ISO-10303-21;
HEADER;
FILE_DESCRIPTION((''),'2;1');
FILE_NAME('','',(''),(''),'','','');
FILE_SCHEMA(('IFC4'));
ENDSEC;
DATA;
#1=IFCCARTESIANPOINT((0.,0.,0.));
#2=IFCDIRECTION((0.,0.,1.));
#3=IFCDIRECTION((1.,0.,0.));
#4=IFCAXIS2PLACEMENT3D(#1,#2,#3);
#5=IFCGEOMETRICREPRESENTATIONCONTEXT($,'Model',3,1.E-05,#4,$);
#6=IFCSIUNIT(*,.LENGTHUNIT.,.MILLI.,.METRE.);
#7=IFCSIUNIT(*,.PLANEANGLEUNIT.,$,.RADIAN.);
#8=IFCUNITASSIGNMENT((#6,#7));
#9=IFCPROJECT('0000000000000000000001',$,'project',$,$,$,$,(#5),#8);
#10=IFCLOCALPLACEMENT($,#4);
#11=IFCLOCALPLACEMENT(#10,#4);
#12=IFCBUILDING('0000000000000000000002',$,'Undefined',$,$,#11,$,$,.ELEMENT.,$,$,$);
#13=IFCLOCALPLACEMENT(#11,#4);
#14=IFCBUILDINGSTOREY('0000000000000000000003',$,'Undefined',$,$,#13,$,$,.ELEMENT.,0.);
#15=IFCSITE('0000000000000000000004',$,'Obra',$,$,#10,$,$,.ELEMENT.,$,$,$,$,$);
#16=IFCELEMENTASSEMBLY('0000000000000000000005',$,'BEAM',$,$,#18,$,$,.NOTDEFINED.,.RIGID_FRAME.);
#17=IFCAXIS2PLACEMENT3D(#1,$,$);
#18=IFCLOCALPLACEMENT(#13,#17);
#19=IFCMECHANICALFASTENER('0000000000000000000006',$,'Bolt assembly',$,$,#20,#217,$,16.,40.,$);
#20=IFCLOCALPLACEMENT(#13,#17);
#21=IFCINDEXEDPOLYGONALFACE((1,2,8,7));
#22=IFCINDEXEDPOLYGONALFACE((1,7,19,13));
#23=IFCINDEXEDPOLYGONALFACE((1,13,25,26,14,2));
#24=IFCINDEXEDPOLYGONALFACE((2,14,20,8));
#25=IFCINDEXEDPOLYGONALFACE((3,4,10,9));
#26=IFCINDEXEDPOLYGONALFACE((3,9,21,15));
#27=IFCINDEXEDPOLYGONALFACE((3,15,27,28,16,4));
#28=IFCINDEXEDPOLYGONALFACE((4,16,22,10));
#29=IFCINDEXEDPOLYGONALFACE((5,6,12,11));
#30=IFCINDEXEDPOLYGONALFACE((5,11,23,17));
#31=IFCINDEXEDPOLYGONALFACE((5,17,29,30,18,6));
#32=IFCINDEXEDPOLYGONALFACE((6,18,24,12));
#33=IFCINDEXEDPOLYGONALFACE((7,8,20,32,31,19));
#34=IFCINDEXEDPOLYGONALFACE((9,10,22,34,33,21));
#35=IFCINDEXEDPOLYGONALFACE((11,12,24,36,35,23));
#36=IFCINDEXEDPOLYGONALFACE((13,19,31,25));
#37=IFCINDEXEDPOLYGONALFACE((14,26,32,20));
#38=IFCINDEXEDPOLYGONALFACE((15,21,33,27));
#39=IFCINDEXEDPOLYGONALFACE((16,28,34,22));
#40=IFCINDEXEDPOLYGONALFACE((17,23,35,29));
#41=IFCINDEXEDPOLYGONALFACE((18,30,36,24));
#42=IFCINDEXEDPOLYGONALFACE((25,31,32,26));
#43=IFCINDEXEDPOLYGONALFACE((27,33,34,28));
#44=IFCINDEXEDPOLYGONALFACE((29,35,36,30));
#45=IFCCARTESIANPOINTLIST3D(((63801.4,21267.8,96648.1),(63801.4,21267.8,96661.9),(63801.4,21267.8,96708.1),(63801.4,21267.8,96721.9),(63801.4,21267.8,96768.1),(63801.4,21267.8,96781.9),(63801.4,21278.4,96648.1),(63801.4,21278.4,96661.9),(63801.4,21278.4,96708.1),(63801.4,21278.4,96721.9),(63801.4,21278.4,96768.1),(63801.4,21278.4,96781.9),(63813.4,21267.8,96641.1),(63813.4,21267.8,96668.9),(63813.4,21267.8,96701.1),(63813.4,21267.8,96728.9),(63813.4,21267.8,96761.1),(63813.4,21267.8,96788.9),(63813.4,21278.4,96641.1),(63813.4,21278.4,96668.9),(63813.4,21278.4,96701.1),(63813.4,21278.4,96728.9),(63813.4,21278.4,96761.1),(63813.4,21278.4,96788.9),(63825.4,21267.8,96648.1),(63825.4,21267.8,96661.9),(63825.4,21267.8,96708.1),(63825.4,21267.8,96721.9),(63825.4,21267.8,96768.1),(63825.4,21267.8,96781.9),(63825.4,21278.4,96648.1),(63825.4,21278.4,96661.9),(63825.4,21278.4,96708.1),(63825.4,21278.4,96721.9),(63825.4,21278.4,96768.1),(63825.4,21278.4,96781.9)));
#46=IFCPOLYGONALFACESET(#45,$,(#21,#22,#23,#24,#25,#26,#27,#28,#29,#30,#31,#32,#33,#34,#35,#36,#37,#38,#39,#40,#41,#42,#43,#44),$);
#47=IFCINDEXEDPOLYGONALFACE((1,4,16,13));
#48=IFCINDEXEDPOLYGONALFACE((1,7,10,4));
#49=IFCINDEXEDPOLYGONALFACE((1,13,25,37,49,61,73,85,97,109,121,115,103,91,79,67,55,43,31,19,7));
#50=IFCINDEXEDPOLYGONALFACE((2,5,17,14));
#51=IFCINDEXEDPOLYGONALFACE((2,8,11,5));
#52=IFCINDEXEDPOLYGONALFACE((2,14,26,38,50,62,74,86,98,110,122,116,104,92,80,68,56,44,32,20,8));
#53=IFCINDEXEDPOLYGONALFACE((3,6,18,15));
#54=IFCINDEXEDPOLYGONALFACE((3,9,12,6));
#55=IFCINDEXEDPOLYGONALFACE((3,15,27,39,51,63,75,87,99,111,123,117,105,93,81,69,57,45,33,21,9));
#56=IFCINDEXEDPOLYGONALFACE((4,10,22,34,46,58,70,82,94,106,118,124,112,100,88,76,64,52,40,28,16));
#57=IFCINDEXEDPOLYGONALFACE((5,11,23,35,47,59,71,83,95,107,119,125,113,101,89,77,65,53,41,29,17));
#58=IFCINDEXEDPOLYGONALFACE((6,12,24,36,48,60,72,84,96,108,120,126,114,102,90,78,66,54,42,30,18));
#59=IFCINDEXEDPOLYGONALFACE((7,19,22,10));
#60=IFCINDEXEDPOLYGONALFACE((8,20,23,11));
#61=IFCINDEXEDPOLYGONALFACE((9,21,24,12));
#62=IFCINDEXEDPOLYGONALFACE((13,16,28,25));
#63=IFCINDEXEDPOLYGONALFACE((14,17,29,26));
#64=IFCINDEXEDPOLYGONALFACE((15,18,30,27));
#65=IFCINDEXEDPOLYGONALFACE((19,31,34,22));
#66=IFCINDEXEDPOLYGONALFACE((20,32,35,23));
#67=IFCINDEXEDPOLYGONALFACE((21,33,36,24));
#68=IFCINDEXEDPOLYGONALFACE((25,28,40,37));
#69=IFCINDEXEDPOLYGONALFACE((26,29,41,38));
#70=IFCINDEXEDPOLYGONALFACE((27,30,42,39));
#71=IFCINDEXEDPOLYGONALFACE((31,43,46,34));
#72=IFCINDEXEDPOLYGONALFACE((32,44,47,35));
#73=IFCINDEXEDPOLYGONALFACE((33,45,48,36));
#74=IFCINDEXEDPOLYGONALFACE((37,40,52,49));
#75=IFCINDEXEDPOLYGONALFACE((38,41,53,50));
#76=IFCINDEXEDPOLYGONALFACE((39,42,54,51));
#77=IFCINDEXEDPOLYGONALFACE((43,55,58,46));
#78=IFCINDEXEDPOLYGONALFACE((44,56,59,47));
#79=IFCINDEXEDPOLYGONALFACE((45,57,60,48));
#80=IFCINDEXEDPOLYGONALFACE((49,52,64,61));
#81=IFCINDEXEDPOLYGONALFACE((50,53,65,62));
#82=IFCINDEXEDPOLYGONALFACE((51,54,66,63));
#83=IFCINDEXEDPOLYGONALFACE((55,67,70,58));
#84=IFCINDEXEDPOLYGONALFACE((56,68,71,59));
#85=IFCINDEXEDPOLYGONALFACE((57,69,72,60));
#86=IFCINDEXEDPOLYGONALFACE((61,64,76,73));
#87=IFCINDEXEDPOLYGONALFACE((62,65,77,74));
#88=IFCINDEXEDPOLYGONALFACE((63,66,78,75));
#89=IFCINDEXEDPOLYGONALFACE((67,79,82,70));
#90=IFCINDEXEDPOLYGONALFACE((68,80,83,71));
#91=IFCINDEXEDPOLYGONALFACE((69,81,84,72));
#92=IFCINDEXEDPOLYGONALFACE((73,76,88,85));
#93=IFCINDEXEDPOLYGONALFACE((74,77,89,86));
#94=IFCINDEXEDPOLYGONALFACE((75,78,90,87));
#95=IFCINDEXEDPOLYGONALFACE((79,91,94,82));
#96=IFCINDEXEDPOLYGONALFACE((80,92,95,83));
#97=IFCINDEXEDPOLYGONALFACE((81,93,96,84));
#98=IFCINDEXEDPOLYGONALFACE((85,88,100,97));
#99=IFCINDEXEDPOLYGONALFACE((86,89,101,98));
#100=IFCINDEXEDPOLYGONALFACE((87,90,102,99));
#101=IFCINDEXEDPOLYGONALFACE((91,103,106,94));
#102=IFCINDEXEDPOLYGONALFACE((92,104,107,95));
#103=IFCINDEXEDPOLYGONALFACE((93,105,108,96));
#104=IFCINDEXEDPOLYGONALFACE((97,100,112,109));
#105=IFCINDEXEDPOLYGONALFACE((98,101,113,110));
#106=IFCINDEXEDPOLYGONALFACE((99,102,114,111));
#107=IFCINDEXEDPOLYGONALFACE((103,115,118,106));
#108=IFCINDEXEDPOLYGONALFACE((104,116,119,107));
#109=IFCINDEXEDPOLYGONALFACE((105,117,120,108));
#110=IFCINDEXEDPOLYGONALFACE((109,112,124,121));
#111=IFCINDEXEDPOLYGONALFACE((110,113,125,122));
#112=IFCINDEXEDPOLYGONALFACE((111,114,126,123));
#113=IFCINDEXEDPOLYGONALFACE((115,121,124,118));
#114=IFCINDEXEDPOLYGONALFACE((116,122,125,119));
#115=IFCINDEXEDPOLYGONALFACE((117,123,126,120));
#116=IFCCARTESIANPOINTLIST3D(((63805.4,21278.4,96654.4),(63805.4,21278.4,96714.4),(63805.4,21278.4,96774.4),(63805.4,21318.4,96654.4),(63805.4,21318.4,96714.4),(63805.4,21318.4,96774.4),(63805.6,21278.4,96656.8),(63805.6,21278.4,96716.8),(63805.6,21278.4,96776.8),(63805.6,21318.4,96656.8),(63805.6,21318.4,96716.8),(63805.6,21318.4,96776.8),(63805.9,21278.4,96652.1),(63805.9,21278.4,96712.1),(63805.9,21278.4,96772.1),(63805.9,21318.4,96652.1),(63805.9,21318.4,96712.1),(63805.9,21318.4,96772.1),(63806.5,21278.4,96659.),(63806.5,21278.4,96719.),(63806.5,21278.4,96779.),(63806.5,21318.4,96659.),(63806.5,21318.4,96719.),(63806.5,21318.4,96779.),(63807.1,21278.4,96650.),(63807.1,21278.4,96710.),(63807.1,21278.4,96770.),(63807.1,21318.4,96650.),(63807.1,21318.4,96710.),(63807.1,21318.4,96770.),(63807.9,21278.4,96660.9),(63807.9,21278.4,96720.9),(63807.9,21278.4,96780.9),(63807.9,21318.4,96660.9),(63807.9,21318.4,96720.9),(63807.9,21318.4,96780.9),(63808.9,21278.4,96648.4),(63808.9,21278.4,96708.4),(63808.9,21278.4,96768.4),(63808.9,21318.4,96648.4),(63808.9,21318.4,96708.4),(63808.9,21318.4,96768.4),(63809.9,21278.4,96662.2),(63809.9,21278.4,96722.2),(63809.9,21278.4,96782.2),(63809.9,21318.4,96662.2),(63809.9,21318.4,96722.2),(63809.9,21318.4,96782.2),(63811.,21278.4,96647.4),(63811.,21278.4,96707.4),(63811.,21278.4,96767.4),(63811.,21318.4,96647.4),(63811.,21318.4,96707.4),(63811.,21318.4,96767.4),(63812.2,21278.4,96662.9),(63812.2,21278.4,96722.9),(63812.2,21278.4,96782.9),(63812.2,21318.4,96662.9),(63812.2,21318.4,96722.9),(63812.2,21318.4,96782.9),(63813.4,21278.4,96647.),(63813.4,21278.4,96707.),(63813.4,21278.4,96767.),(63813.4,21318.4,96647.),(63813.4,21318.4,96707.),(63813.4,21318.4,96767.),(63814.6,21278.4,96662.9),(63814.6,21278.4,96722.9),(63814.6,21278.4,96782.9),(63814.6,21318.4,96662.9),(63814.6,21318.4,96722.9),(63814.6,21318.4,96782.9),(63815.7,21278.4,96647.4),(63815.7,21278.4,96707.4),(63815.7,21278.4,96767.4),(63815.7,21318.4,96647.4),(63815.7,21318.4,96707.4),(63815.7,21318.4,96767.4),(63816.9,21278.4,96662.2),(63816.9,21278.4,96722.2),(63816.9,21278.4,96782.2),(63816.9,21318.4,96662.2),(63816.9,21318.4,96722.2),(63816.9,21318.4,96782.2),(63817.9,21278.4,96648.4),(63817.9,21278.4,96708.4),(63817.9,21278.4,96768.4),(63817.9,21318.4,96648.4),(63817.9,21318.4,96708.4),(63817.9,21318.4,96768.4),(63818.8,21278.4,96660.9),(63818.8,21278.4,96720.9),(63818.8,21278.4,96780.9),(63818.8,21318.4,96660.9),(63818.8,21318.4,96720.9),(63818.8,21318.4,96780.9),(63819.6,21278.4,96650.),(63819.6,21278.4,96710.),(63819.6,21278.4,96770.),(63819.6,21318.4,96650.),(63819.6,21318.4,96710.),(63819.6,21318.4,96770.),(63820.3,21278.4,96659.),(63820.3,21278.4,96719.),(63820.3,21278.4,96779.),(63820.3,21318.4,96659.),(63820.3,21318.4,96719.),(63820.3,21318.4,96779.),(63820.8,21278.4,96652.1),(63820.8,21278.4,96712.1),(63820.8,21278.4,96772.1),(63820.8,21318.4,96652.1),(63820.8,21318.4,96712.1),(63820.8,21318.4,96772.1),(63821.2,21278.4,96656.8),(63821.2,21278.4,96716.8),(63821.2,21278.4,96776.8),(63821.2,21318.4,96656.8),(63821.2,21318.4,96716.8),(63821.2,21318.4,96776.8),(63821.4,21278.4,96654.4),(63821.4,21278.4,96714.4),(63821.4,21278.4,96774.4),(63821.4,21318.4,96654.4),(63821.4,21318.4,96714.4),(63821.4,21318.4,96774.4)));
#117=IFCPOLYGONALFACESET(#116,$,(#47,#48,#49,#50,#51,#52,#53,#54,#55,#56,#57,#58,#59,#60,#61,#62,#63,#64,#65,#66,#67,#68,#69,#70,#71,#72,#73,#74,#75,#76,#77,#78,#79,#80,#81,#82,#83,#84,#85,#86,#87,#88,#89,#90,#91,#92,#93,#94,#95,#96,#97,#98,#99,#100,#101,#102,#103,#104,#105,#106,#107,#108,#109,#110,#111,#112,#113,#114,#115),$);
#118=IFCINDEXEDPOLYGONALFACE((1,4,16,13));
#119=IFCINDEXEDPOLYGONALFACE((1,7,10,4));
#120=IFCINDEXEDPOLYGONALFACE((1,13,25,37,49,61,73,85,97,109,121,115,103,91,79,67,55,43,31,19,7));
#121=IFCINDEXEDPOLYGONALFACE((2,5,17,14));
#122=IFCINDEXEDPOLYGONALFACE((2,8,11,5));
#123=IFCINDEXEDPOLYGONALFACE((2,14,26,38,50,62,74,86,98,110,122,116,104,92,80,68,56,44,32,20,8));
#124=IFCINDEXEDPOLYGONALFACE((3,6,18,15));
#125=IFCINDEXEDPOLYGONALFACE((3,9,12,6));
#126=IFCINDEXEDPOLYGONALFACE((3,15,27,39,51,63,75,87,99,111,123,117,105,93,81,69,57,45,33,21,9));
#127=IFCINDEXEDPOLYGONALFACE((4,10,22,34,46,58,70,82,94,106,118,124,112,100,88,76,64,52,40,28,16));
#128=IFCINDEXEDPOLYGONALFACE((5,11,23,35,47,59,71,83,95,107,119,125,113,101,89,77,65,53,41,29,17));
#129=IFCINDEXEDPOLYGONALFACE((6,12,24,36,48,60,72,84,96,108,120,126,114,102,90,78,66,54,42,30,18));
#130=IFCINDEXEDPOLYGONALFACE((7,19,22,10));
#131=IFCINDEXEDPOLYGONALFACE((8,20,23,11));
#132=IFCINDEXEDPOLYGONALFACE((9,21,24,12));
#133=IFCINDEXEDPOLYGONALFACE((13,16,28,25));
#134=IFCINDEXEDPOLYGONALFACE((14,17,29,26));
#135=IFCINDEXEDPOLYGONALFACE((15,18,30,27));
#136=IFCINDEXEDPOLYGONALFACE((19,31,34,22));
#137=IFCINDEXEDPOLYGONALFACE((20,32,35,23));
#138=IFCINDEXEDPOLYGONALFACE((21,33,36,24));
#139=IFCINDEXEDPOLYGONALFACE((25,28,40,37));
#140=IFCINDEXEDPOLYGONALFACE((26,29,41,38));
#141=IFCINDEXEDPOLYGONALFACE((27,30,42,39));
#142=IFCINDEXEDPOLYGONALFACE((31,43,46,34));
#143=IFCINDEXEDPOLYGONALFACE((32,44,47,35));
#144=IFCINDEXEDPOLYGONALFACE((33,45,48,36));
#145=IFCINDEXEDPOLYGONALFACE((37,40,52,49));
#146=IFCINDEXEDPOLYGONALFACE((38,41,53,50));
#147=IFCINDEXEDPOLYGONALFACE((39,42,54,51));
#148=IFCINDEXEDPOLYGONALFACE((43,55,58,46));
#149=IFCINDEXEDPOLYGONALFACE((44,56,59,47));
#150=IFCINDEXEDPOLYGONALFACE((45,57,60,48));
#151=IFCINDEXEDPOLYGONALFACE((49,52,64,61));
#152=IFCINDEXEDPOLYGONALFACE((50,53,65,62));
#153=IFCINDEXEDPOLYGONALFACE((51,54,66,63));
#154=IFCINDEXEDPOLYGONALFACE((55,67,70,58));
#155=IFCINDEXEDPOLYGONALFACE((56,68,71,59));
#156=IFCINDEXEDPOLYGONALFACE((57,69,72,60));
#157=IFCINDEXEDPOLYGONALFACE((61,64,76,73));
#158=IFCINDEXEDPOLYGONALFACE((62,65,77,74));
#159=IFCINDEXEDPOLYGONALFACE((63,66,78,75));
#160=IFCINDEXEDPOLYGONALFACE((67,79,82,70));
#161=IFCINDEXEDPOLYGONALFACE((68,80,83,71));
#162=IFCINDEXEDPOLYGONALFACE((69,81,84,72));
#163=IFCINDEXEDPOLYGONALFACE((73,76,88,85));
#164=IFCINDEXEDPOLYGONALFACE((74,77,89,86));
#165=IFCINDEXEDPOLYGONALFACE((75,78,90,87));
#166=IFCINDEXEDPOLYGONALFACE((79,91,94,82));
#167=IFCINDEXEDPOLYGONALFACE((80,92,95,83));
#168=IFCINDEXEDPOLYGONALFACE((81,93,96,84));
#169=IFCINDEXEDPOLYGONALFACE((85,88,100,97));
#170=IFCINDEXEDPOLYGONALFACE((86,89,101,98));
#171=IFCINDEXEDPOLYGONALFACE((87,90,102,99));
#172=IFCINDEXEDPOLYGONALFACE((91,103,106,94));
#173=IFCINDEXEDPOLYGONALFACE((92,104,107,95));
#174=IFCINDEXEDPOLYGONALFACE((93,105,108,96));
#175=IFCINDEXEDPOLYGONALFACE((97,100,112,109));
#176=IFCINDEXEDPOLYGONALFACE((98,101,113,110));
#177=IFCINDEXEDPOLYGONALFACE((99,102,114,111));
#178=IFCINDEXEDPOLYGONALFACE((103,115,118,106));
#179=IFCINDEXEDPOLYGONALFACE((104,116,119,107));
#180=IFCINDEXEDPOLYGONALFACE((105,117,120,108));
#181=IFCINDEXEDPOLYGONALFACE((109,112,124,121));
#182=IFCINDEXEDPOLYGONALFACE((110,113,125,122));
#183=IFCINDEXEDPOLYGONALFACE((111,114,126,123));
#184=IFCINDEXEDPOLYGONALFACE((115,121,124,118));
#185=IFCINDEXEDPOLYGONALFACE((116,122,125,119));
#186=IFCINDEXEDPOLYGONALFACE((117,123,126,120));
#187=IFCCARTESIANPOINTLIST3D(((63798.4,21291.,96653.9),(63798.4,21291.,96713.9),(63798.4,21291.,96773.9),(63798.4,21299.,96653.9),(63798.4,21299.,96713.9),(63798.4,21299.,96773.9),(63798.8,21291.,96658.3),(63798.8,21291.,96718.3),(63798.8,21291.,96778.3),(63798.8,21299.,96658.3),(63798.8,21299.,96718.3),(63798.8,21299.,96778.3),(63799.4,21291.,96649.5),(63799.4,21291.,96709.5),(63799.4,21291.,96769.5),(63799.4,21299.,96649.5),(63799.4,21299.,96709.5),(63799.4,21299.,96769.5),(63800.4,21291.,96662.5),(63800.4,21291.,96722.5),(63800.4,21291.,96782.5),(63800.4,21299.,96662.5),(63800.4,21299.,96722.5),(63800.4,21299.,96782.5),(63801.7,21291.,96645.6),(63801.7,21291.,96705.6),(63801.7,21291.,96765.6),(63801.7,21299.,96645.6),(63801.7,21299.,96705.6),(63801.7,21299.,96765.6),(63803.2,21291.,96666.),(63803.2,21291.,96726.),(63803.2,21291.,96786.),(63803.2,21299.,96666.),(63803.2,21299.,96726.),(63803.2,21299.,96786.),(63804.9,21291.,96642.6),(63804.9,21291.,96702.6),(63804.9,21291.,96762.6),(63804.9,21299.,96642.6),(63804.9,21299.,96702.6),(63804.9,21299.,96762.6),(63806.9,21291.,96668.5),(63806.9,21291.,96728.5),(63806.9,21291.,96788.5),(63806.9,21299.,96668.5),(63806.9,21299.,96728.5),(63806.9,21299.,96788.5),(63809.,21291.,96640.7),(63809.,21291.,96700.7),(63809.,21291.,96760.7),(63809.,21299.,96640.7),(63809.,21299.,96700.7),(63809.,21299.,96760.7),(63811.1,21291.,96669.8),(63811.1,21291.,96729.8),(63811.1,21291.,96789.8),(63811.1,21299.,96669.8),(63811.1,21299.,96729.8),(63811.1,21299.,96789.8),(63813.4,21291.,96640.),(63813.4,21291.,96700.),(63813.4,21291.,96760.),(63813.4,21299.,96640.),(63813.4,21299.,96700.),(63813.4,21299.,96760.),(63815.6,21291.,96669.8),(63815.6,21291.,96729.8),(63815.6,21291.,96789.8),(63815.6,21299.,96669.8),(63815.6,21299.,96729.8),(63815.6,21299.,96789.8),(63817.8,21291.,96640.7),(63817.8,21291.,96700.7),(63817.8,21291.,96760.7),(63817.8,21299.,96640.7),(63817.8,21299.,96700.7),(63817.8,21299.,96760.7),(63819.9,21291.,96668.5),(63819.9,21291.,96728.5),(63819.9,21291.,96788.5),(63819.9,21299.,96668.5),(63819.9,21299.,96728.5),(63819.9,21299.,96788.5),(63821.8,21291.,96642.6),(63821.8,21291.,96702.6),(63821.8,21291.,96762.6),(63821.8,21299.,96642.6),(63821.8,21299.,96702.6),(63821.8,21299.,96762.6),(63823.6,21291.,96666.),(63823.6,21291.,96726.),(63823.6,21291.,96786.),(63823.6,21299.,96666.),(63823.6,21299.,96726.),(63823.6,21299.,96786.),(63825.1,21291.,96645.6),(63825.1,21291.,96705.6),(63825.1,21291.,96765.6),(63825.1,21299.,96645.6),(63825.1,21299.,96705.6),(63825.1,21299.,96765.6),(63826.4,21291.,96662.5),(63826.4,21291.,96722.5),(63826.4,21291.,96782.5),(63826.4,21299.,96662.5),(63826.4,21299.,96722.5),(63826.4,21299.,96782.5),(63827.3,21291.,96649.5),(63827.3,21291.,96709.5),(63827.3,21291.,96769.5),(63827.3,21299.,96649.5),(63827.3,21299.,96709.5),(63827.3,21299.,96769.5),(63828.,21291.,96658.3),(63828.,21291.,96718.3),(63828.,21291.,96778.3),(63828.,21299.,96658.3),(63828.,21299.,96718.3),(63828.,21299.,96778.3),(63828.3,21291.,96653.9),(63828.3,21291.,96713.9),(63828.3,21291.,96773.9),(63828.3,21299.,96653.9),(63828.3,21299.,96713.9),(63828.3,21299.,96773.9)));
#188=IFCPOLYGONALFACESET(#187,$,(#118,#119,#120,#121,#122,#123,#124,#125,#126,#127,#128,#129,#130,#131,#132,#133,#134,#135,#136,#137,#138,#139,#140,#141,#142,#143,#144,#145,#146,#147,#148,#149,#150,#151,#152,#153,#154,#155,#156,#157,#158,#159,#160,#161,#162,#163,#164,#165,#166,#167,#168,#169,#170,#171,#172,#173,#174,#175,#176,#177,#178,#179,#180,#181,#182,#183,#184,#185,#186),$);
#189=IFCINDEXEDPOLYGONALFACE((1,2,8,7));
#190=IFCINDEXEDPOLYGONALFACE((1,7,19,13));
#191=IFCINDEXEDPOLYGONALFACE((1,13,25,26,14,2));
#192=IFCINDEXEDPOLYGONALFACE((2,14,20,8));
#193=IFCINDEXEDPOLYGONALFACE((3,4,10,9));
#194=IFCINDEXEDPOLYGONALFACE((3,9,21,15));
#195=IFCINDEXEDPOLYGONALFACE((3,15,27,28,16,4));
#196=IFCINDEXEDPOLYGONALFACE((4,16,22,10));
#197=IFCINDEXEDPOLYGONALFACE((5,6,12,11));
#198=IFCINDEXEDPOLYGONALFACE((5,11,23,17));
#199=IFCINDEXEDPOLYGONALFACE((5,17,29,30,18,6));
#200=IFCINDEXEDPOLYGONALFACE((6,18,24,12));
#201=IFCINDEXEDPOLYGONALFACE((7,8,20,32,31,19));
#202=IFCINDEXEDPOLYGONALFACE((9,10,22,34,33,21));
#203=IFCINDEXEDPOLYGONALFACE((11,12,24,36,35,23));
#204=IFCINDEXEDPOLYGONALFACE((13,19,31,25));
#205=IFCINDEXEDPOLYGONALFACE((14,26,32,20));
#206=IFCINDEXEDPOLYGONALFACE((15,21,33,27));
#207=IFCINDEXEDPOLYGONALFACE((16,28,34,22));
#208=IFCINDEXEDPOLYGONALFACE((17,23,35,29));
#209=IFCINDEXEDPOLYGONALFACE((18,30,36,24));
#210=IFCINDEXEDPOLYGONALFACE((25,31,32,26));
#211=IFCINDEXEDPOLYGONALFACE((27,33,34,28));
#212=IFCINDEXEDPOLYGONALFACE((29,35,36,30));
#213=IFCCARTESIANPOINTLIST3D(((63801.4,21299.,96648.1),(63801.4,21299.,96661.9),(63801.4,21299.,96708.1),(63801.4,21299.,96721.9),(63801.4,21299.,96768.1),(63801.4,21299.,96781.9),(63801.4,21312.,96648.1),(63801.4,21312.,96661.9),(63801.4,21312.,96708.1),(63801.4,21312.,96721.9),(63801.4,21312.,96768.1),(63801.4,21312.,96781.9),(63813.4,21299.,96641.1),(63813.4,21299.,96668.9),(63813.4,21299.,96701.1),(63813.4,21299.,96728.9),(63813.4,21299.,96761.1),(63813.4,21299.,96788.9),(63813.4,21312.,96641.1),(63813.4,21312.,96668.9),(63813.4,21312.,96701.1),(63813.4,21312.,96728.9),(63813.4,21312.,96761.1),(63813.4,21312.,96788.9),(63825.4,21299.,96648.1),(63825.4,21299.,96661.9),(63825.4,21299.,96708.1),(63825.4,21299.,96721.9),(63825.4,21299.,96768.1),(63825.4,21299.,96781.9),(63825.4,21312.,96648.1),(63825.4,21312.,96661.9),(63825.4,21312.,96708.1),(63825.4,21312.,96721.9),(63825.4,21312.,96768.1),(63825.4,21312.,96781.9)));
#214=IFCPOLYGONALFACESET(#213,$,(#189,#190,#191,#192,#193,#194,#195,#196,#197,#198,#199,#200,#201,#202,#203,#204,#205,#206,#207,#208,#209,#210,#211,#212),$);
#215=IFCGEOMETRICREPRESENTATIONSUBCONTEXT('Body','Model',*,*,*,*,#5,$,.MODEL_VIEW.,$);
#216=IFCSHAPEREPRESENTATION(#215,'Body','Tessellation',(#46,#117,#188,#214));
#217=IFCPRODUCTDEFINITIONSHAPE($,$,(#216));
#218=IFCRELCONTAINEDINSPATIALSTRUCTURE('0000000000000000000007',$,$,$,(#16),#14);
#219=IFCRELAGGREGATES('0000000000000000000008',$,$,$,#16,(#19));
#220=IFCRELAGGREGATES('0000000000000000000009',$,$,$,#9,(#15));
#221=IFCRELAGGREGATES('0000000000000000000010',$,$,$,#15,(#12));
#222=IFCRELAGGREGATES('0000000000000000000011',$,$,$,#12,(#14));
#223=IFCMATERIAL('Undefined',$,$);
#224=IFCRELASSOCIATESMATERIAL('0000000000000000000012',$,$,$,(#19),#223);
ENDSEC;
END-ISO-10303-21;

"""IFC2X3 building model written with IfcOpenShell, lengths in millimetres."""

from ifc_helpers import new_model, si_unit, frame, origin_with_axes, origin_2d_with_axis, place, context, subcontext, project, spatial, polyline, circle, outline, extrude, source, transform, mapped, material, element, aggregate, save


model = new_model("IFC2X3")

# Units and contexts
model_context = context("Model", 3, precision=1e-05, world=origin_with_axes())
body_context = subcontext(model_context, "Body", "Model", "MODEL_VIEW")
ifc_project = project(units=[si_unit("LENGTHUNIT", "METRE", prefix="MILLI"), si_unit("PLANEANGLEUNIT", "RADIAN")], contexts=[model_context])

# Site, building, storey
site_placement = place(None, origin_with_axes())
site = spatial("IfcSite", under=ifc_project, at=site_placement, Name="Obra", CompositionType="ELEMENT")
building_placement = place(site_placement, origin_with_axes())
building = spatial("IfcBuilding", under=site, at=building_placement, Name="Undefined", CompositionType="ELEMENT")
storey_placement = place(building_placement, origin_with_axes())
storey = spatial("IfcBuildingStorey", under=building, at=storey_placement, Name="Undefined", CompositionType="ELEMENT", Elevation=0.0)

# Shared definitions
ifc_material_1 = material(Name="Undefined")

# Element assembly, mechanical fastener
shared_shape_1 = source(origin_with_axes(), body_context, "Body", "SweptSolid", [
    extrude(outline(polyline([(13.9, 0.0), (6.9, 12.0), (-6.9, 12.0), (-13.9, 0.0), (-6.9, -12.0), (6.9, -12.0), (13.9, 0.0)])), frame((0.0, -19.9, 0.0), z_axis=(0.0, 1.0, 0.0), x_axis=(1.0, 0.0, 0.0)), (0.0, 0.0, 1.0), 10.6),
    extrude(circle(Radius=8.0, at=origin_2d_with_axis()), frame((0.0, -9.3, 0.0), z_axis=(0.0, 1.0, 0.0), x_axis=(1.0, 0.0, 0.0)), (0.0, 0.0, 1.0), 40.0),
    extrude(circle(Radius=15.0, at=origin_2d_with_axis()), frame((0.0, 3.3, 0.0), z_axis=(0.0, 1.0, 0.0), x_axis=(1.0, 0.0, 0.0)), (0.0, 0.0, 1.0), 8.0),
    extrude(outline(polyline([(13.9, 0.0), (6.9, 12.0), (-6.9, 12.0), (-13.9, 0.0), (-6.9, -12.0), (6.9, -12.0), (13.9, 0.0)])), frame((0.0, 11.3, 0.0), z_axis=(0.0, 1.0, 0.0), x_axis=(1.0, 0.0, 0.0)), (0.0, 0.0, 1.0), 13.0),
])
assembly_1_placement = place(storey_placement, origin_with_axes())
assembly_1 = element("IfcElementAssembly", 1, at=assembly_1_placement, inside=storey, Name="BEAM", AssemblyPlace="NOTDEFINED", PredefinedType="RIGID_FRAME")
mechanical_fastener_1_placement = place(assembly_1_placement, frame((63763.4, 21287.7, 96850.0), z_axis=(1.0, 0.0, 0.0), x_axis=(0.0, 0.0, -1.0)))
mechanical_fastener_1 = element("IfcMechanicalFastener", 2, at=mechanical_fastener_1_placement, material=ifc_material_1, Name="Bolt assembly", NominalDiameter=16.0, NominalLength=40.0, context=body_context, shape_type="MappedRepresentation", body=[
    mapped(shared_shape_1, transform((75.0, 0.0, 50.0))),
    mapped(shared_shape_1, transform((135.0, 0.0, 50.0))),
    mapped(shared_shape_1, transform((195.0, 0.0, 50.0))),
])
aggregate(assembly_1, [mechanical_fastener_1])

save(model, "model.ifc")
